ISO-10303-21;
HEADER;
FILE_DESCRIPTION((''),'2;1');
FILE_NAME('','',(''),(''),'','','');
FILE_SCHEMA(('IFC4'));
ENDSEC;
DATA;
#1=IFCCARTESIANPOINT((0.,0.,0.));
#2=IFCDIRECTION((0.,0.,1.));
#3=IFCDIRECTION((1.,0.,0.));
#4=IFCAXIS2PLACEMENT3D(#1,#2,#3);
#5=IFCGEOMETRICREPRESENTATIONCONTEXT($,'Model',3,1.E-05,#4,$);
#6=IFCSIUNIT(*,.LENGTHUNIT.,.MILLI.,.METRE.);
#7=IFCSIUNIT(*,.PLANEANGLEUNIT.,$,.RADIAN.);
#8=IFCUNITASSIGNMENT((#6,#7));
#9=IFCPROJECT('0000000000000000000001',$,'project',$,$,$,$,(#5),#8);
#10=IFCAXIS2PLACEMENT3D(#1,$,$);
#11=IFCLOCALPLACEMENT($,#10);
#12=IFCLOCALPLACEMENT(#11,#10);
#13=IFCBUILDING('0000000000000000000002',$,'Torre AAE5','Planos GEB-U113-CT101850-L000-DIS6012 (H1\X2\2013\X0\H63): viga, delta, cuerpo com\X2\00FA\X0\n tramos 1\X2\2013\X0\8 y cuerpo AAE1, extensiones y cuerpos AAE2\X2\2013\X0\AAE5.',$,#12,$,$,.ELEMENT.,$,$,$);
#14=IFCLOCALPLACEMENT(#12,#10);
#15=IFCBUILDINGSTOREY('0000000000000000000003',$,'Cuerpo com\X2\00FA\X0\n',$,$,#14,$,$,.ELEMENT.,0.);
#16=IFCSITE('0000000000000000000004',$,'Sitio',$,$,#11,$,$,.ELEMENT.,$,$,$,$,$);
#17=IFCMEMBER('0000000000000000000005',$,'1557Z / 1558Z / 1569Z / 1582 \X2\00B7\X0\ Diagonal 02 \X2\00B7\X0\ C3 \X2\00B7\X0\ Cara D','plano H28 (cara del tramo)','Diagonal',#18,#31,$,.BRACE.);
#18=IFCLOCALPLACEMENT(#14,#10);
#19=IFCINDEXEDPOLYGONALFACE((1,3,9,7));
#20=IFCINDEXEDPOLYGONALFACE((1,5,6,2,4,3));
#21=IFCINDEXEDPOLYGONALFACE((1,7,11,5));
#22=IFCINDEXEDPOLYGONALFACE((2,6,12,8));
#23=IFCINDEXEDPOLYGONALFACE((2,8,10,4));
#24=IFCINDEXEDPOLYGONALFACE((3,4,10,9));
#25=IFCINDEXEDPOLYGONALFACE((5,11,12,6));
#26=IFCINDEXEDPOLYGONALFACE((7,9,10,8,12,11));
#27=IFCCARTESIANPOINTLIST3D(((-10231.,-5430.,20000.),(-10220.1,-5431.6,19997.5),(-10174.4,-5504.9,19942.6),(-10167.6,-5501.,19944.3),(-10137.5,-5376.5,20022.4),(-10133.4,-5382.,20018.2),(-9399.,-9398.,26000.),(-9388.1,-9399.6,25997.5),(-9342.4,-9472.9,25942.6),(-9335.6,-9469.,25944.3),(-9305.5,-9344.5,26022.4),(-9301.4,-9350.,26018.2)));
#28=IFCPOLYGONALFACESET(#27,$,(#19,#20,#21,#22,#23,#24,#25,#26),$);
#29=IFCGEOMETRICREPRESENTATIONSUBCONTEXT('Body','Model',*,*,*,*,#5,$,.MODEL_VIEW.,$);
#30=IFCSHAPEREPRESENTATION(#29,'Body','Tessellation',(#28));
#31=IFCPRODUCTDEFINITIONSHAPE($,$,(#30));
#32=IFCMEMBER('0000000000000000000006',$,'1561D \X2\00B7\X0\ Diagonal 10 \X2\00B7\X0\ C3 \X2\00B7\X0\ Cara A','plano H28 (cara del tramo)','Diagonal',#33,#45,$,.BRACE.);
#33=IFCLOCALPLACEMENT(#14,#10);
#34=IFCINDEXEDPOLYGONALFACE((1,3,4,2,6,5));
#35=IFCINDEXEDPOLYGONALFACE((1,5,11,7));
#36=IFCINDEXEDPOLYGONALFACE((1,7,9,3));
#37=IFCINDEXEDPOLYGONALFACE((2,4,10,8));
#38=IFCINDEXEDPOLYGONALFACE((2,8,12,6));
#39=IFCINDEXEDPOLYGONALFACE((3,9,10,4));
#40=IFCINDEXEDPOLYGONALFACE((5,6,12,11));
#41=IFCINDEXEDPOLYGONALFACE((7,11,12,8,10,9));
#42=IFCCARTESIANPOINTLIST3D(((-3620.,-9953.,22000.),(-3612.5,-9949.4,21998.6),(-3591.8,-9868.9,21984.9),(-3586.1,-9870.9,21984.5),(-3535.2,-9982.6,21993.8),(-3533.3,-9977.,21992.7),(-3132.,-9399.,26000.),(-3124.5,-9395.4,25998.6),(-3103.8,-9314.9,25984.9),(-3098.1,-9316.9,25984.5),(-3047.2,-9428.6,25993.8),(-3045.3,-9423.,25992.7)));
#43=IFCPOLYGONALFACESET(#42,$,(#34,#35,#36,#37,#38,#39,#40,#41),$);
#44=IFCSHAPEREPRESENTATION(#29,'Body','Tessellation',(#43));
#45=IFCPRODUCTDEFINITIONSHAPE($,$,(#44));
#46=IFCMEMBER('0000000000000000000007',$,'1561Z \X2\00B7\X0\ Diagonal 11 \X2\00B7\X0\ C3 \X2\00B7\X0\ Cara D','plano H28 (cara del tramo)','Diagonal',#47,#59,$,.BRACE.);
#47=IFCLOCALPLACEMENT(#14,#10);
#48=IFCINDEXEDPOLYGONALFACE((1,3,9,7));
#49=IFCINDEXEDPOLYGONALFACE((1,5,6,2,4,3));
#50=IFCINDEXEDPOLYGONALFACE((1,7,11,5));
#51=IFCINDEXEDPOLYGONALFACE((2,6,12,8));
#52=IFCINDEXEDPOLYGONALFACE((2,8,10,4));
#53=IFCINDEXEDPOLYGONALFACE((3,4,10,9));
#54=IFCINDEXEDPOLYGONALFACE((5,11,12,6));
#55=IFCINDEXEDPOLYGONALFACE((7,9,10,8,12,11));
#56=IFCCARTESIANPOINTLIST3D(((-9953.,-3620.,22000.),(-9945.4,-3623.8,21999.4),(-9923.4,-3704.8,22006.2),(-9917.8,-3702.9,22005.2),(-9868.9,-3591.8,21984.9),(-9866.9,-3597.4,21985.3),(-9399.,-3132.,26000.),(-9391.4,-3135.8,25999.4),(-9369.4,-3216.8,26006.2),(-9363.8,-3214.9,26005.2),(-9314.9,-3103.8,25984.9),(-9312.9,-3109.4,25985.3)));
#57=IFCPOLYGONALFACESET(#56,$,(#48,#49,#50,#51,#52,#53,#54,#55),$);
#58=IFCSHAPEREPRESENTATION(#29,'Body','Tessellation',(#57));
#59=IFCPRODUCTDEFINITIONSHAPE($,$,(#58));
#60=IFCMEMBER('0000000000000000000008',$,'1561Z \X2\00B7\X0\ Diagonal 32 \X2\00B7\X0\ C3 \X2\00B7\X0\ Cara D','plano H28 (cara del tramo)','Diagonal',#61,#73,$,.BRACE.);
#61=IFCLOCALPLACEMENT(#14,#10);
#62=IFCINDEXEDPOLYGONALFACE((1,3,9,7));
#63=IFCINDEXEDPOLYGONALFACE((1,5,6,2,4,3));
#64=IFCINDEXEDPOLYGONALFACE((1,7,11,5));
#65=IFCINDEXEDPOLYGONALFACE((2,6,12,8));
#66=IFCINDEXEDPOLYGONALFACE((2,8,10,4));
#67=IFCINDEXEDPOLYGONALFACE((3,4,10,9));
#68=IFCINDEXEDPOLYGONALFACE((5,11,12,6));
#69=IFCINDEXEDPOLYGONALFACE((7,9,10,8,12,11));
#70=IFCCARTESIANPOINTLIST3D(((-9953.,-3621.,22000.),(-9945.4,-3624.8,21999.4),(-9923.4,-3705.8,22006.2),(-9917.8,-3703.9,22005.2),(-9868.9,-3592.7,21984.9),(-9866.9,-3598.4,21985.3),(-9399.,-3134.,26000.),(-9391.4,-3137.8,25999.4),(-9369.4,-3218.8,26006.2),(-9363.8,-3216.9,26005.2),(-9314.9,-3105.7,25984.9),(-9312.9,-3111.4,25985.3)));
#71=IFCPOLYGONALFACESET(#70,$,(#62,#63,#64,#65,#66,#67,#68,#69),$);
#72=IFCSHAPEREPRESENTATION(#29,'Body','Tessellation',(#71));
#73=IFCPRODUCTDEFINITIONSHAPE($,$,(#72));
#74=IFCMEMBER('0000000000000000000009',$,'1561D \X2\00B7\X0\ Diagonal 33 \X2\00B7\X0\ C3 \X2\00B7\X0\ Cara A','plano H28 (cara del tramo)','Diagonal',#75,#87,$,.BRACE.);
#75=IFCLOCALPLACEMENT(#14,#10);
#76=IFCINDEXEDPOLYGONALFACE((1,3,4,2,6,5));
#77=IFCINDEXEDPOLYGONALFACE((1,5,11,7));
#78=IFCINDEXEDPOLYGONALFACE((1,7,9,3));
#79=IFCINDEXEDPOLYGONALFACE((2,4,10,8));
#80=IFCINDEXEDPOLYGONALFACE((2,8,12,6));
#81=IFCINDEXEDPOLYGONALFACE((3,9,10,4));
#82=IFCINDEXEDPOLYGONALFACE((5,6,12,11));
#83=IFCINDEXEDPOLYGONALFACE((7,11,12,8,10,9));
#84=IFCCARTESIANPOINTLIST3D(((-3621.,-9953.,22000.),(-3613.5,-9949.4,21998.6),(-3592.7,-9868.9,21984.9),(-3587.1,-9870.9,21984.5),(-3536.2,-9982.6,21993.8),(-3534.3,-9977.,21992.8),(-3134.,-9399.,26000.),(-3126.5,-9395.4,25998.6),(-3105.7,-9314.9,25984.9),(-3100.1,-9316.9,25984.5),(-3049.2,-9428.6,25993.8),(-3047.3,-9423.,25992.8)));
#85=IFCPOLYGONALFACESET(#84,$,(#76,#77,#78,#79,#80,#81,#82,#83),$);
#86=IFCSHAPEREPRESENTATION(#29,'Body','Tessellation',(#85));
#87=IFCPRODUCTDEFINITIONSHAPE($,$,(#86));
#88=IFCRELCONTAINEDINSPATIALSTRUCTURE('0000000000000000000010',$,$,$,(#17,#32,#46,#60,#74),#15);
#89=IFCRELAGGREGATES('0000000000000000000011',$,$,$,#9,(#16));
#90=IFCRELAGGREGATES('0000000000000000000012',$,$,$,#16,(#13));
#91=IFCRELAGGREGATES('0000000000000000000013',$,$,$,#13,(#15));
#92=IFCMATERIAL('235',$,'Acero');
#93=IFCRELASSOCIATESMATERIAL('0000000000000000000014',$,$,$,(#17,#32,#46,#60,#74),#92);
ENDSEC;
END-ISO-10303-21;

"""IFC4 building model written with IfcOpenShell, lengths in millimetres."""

from ifc_helpers import new_model, si_unit, frame, frame_2d, origin, origin_with_axes, place, context, subcontext, project, spatial, l_section, extrude, material, element, save


model = new_model("IFC4")

# Units and contexts
model_context = context("Model", 3, precision=1e-05, world=origin_with_axes())
body_context = subcontext(model_context, "Body", "Model", "MODEL_VIEW")
ifc_project = project(units=[si_unit("LENGTHUNIT", "METRE", prefix="MILLI"), si_unit("PLANEANGLEUNIT", "RADIAN")], contexts=[model_context])

# Site, building, storey
site_placement = place(None, origin())
site = spatial("IfcSite", under=ifc_project, at=site_placement, Name="Sitio", CompositionType="ELEMENT")
building_placement = place(site_placement, origin())
building = spatial("IfcBuilding", under=site, at=building_placement, Name="Torre AAE5", Description="Planos GEB-U113-CT101850-L000-DIS6012 (H1–H63): viga, delta, cuerpo común tramos 1–8 y cuerpo AAE1, extensiones y cuerpos AAE2–AAE5.", CompositionType="ELEMENT")
storey_placement = place(building_placement, origin())
storey = spatial("IfcBuildingStorey", under=building, at=storey_placement, Name="Cuerpo común", CompositionType="ELEMENT", Elevation=0.0)

# Members
ifc_material_1 = material(Name="235", Category="Acero")
member_1_placement = place(storey_placement, frame((-9399.0, -9398.0, 26000.0), z_axis=(-0.114896, 0.547964, -0.828574), x_axis=(0.849898, 0.486034, 0.203578)))
element("IfcMember", 1, at=member_1_placement, inside=storey, material=ifc_material_1, Name="1557Z / 1558Z / 1569Z / 1582 · Diagonal 02 · C3 · Cara D", Description="plano H28 (cara del tramo)", ObjectType="Diagonal", PredefinedType="BRACE", context=body_context, shape_type="SweptSolid", body=[
    extrude(l_section(Depth=110.0, Width=110.0, Thickness=8.0, at=frame_2d((55.0, 55.0))), None, (0.0, 0.0, 1.0), 7241.4),
])
for number, where, z_axis, x_axis, name in (
    (2, (-3132.0, -9399.0, 26000.0), (-0.119974, -0.1362, -0.98339), (0.313724, 0.934585, -0.167714), "1561D · Diagonal 10 · C3 · Cara A"),
    (3, (-9399.0, -3132.0, 26000.0), (-0.1362, -0.119974, -0.98339), (0.934585, 0.313724, -0.167714), "1561Z · Diagonal 11 · C3 · Cara D"),
):
    element("IfcMember", number, at=place(storey_placement, frame(where, z_axis=z_axis, x_axis=x_axis)), inside=storey, material=ifc_material_1, Name=name, Description="plano H28 (cara del tramo)", ObjectType="Diagonal", PredefinedType="BRACE", context=body_context, shape_type="SweptSolid", body=[
        extrude(l_section(Depth=90.0, Width=90.0, Thickness=6.0, at=frame_2d((45.0, 45.0))), None, (0.0, 0.0, 1.0), 4067.6),
    ])
for number, where, z_axis, x_axis, name in (
    (4, (-9399.0, -3134.0, 26000.0), (-0.136204, -0.119731, -0.983419), (0.934536, 0.313902, -0.167651), "1561Z · Diagonal 32 · C3 · Cara D"),
    (5, (-3134.0, -9399.0, 26000.0), (-0.119731, -0.136204, -0.983419), (0.313902, 0.934536, -0.167651), "1561D · Diagonal 33 · C3 · Cara A"),
):
    element("IfcMember", number, at=place(storey_placement, frame(where, z_axis=z_axis, x_axis=x_axis)), inside=storey, material=ifc_material_1, Name=name, Description="plano H28 (cara del tramo)", ObjectType="Diagonal", PredefinedType="BRACE", context=body_context, shape_type="SweptSolid", body=[
        extrude(l_section(Depth=90.0, Width=90.0, Thickness=6.0, at=frame_2d((45.0, 45.0))), None, (0.0, 0.0, 1.0), 4067.4),
    ])

save(model, "model.ifc")
